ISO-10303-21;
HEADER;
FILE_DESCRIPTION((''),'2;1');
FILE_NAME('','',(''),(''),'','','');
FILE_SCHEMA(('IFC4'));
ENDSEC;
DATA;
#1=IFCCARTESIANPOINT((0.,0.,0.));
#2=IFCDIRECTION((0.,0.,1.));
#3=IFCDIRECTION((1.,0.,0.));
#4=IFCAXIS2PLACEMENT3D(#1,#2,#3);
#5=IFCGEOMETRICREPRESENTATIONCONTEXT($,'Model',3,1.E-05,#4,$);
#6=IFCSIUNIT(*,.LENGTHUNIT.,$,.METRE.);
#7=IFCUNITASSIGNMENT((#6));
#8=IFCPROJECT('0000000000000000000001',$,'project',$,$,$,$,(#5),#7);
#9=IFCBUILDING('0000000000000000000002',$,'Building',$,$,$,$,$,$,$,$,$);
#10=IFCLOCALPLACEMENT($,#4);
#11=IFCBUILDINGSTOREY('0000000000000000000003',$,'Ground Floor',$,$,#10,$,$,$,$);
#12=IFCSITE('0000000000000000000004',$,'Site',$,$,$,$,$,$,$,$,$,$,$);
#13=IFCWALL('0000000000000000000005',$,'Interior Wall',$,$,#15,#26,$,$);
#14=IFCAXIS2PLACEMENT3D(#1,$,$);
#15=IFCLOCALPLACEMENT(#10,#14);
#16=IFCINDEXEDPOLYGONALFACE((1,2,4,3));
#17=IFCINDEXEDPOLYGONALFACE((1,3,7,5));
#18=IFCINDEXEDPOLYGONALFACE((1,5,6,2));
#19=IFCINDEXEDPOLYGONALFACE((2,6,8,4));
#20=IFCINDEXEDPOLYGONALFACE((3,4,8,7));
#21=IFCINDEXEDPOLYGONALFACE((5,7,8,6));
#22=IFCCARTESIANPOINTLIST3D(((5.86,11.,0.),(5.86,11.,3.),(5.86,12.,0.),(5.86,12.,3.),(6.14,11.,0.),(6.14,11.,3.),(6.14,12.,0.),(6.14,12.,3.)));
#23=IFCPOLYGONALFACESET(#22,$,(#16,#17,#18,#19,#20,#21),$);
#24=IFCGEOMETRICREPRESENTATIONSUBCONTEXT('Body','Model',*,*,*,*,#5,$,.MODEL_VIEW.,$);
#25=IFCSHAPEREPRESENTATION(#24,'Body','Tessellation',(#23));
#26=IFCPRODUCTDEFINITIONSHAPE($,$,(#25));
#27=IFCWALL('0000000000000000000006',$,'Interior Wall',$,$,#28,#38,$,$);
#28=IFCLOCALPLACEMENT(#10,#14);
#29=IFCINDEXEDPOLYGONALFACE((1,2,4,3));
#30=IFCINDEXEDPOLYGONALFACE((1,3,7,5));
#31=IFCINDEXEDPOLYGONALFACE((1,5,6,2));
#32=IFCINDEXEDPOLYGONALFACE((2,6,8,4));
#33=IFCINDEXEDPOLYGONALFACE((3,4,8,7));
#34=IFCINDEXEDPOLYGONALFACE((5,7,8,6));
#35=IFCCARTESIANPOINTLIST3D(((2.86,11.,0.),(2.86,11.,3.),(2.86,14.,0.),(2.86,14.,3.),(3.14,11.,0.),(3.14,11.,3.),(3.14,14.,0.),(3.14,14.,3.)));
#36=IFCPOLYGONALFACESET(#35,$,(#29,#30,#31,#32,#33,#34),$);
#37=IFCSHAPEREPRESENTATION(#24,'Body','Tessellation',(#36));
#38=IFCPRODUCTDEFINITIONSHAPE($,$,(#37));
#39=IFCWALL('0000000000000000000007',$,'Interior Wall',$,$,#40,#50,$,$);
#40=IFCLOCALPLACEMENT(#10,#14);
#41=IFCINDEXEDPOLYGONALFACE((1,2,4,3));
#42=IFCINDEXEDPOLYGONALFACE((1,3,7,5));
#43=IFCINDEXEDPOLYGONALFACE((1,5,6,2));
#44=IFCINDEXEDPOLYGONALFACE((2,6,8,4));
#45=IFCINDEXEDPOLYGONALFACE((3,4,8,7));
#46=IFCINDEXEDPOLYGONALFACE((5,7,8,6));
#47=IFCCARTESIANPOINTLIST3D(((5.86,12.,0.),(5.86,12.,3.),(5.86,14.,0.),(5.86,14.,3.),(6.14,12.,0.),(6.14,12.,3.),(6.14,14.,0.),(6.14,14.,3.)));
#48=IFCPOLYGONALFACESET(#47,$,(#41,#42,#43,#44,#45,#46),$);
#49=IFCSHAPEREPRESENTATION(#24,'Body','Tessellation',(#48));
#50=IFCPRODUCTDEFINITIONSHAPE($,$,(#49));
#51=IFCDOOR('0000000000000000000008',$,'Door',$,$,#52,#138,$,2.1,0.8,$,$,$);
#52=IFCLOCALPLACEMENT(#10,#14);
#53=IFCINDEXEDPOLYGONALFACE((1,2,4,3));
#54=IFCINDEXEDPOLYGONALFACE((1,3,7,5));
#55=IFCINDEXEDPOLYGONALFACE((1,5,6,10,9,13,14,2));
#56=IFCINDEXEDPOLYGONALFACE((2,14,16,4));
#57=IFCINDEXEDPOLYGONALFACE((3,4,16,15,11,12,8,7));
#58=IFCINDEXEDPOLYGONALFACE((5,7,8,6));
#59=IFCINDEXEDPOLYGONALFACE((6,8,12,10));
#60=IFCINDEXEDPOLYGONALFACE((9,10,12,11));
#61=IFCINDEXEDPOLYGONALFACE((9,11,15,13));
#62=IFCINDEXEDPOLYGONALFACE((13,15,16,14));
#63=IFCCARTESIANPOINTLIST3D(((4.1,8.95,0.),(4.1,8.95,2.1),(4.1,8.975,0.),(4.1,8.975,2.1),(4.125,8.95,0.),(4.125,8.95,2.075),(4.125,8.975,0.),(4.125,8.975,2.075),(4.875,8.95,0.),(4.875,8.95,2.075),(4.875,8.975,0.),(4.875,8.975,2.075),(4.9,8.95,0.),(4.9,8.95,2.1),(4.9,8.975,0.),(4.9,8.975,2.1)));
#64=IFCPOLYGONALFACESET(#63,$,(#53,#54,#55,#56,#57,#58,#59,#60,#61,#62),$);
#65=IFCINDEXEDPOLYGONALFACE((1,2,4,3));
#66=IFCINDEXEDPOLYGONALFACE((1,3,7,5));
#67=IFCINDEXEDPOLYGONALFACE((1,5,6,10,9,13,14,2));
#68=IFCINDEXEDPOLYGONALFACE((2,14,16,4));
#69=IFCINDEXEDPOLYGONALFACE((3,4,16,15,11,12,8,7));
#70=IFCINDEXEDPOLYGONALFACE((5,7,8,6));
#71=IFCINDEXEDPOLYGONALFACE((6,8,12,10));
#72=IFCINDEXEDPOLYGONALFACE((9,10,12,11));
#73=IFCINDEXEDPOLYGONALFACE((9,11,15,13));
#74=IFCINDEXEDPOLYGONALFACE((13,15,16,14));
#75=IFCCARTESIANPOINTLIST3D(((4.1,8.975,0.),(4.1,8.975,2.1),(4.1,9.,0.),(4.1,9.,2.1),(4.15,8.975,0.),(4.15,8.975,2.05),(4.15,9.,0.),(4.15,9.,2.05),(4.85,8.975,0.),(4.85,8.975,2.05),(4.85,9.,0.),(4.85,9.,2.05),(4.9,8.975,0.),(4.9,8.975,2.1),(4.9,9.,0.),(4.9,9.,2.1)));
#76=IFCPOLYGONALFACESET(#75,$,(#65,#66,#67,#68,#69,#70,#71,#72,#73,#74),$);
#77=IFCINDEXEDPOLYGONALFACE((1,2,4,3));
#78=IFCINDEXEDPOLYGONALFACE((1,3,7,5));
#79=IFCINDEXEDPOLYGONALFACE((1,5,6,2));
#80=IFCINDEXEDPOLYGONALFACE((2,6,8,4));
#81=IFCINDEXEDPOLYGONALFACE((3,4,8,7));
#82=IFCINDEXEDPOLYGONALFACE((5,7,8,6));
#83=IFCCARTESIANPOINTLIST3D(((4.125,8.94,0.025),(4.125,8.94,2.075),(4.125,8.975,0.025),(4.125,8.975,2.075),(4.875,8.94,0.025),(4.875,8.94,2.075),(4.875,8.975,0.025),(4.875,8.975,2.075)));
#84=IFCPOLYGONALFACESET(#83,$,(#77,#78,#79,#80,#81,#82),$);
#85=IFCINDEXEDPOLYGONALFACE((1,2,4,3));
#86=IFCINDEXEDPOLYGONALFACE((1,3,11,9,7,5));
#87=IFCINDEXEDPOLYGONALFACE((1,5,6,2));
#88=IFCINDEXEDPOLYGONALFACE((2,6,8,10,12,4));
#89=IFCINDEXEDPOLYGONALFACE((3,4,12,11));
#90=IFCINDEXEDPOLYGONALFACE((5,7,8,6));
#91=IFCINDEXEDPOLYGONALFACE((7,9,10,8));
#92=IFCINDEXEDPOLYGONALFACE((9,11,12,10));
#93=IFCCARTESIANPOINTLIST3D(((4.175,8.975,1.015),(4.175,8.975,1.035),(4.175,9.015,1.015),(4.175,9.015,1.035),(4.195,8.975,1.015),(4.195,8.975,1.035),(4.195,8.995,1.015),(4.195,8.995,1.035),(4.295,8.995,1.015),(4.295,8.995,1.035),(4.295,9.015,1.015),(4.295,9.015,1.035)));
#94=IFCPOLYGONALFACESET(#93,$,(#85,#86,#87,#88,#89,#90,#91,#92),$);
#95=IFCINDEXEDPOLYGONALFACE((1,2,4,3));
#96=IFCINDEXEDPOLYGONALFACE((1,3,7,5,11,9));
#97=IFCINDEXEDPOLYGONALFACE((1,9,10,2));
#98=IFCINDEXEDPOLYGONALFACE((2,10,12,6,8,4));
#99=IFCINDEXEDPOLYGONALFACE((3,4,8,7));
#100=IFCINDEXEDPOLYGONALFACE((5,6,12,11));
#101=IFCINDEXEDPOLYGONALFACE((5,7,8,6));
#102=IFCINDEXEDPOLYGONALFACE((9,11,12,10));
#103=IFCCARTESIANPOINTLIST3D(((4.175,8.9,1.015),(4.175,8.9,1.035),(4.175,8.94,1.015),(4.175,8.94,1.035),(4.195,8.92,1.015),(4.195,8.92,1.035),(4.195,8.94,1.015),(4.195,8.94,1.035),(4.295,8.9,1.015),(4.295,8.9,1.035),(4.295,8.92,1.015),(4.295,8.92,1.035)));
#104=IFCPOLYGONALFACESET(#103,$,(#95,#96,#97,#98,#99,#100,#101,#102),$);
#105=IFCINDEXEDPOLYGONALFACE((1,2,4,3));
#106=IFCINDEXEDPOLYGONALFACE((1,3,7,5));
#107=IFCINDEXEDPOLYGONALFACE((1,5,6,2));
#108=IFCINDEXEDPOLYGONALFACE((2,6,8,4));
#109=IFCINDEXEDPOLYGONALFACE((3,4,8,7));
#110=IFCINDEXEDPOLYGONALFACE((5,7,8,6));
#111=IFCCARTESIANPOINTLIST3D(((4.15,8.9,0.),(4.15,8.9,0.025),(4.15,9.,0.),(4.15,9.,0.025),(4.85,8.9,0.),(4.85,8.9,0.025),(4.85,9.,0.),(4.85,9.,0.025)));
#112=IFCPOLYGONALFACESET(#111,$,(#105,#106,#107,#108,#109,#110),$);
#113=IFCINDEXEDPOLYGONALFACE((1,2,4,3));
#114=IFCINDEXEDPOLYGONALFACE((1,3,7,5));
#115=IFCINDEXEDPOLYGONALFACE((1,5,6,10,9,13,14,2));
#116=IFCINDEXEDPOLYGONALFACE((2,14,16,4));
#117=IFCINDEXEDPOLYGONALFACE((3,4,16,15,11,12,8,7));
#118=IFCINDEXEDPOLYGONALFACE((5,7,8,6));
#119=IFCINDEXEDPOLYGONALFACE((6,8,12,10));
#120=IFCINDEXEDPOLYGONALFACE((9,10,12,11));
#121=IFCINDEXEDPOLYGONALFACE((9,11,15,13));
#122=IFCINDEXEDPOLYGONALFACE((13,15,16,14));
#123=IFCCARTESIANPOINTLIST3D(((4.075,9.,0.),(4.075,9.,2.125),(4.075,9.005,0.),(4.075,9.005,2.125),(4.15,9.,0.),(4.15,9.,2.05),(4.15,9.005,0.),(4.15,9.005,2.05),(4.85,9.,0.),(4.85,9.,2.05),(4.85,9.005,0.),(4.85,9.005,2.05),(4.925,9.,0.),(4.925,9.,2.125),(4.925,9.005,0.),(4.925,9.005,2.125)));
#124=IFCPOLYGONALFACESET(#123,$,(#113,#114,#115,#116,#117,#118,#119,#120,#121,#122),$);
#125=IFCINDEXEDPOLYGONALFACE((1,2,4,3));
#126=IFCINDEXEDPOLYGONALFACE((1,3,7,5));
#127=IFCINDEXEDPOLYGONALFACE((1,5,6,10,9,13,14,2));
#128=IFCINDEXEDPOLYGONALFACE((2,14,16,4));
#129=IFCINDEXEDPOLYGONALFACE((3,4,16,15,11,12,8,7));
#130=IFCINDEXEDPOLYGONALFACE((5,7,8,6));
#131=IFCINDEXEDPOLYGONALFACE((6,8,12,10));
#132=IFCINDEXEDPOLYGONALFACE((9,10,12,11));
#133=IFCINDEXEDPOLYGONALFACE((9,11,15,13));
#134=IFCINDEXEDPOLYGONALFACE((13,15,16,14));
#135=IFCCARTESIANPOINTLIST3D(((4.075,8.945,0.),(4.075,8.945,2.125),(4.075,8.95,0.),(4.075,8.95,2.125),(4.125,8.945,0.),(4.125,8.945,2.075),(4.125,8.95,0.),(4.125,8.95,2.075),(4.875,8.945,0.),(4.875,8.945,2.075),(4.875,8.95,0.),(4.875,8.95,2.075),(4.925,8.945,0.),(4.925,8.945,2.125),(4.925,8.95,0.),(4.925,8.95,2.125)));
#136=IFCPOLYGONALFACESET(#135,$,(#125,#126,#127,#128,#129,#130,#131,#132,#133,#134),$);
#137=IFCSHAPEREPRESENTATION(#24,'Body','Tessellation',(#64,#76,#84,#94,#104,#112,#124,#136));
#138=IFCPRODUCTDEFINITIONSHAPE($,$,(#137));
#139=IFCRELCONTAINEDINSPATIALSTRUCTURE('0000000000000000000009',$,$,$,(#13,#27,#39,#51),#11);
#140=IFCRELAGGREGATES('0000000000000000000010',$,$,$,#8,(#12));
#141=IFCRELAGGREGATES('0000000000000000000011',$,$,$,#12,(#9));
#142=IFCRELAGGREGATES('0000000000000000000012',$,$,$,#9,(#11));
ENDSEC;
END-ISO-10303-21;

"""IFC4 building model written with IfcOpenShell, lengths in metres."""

from ifc_helpers import new_model, si_unit, frame, origin_with_axes, place, context, subcontext, project, spatial, line, indexed_curve, outline, extrude, element, save


model = new_model("IFC4")

# Units and contexts
model_context = context("Model", 3, precision=1e-05, world=origin_with_axes())
body_context = subcontext(model_context, "Body", "Model", "MODEL_VIEW")
ifc_project = project(units=[si_unit("LENGTHUNIT", "METRE")], contexts=[model_context])

# Site, building, storey
site = spatial("IfcSite", under=ifc_project, Name="Site")
building = spatial("IfcBuilding", under=site, Name="Building")
storey_placement = place(None, origin_with_axes())
storey = spatial("IfcBuildingStorey", under=building, at=storey_placement, Name="Ground Floor")

# Walls
wall_1_placement = place(storey_placement, frame((6.0, 12.0, 0.0), z_axis=(0.0, 0.0, 1.0), x_axis=(0.0, -1.0, 0.0)))
element("IfcWall", 1, at=wall_1_placement, inside=storey, Name="Interior Wall", context=body_context, shape_type="SweptSolid", body=[
    extrude(outline(indexed_curve([(0.0, 0.0), (0.0, 0.28), (1.0, 0.28), (1.0, 0.0), (0.0, 0.0)], self_intersect=False)), frame((0.0, -0.14, 0.0), z_axis=(0.0, 0.0, 1.0), x_axis=(1.0, 0.0, 0.0)), (0.0, 0.0, 1.0), 3.0),
])
wall_2_placement = place(storey_placement, frame((3.0, 11.0, 0.0), z_axis=(0.0, 0.0, 1.0), x_axis=(0.0, 1.0, 0.0)))
element("IfcWall", 2, at=wall_2_placement, inside=storey, Name="Interior Wall", context=body_context, shape_type="SweptSolid", body=[
    extrude(outline(indexed_curve([(0.0, 0.0), (0.0, 0.28), (3.0, 0.28), (3.0, 0.0), (0.0, 0.0)], self_intersect=False)), frame((0.0, -0.14, 0.0), z_axis=(0.0, 0.0, 1.0), x_axis=(1.0, 0.0, 0.0)), (0.0, 0.0, 1.0), 3.0),
])
wall_3_placement = place(storey_placement, frame((6.0, 12.0, 0.0), z_axis=(0.0, 0.0, 1.0), x_axis=(0.0, 1.0, 0.0)))
element("IfcWall", 3, at=wall_3_placement, inside=storey, Name="Interior Wall", context=body_context, shape_type="SweptSolid", body=[
    extrude(outline(indexed_curve([(0.0, 0.0), (0.0, 0.28), (2.0, 0.28), (2.0, 0.0), (0.0, 0.0)], self_intersect=False)), frame((0.0, -0.14, 0.0), z_axis=(0.0, 0.0, 1.0), x_axis=(1.0, 0.0, 0.0)), (0.0, 0.0, 1.0), 3.0),
])

# Door
door_1_placement = place(storey_placement, frame((4.9, 9.0, 0.0), z_axis=(0.0, 0.0, 1.0), x_axis=(-1.0, 0.0, 0.0)))
element("IfcDoor", 4, at=door_1_placement, inside=storey, Name="Door", OverallHeight=2.1, OverallWidth=0.8, context=body_context, shape_type="SweptSolid", body=[
    extrude(outline(indexed_curve([(0.0, 0.0), (0.0, 2.1), (0.8, 2.1), (0.8, 0.0), (0.775, 0.0), (0.775, 2.075), (0.025, 2.075), (0.025, 0.0)], segments=[line(1, 2, 3, 4, 5, 6, 7, 8, 1)])), frame((0.0, 0.025, 0.0), z_axis=(0.0, -1.0, 0.0), x_axis=(1.0, 0.0, 0.0)), (0.0, 0.0, -1.0), 0.025),
    extrude(outline(indexed_curve([(0.0, 0.0), (0.0, 2.1), (0.8, 2.1), (0.8, 0.0), (0.75, 0.0), (0.75, 2.05), (0.05, 2.05), (0.05, 0.0)], segments=[line(1, 2, 3, 4, 5, 6, 7, 8, 1)])), frame((0.0, 0.0, 0.0), z_axis=(0.0, -1.0, 0.0), x_axis=(1.0, 0.0, 0.0)), (0.0, 0.0, -1.0), 0.025),
    extrude(outline(indexed_curve([(0.0, 0.0), (0.75, 0.0), (0.75, 0.035), (0.0, 0.035)], segments=[line(1, 2, 3, 4, 1)])), frame((0.025, 0.025, 0.025), z_axis=(0.0, 0.0, 1.0), x_axis=(1.0, 0.0, 0.0)), (0.0, 0.0, 1.0), 2.05),
    extrude(outline(indexed_curve([(0.0, 0.0), (0.0, -0.04), (-0.12, -0.04), (-0.12, -0.02), (-0.02, -0.02), (-0.02, 0.0)], segments=[line(1, 2, 3, 4, 5, 6, 1)])), frame((0.725, 0.025, 1.015), z_axis=(0.0, 0.0, 1.0), x_axis=(1.0, 0.0, 0.0)), (0.0, 0.0, 1.0), 0.02),
    extrude(outline(indexed_curve([(0.0, 0.0), (0.0, 0.04), (-0.12, 0.04), (-0.12, 0.02), (-0.02, 0.02), (-0.02, 0.0)], segments=[line(1, 2, 3, 4, 5, 6, 1)])), frame((0.725, 0.06, 1.015), z_axis=(0.0, 0.0, 1.0), x_axis=(1.0, 0.0, 0.0)), (0.0, 0.0, 1.0), 0.02),
    extrude(outline(indexed_curve([(0.0, 0.0), (0.7, 0.0), (0.7, 0.1), (0.0, 0.1)], segments=[line(1, 2, 3, 4, 1)])), frame((0.05, 0.0, 0.0), z_axis=(0.0, 0.0, 1.0), x_axis=(1.0, 0.0, 0.0)), (0.0, 0.0, 1.0), 0.025),
    extrude(outline(indexed_curve([(0.0, 0.0), (0.0, 2.125), (0.85, 2.125), (0.85, 0.0), (0.775, 0.0), (0.775, 2.05), (0.075, 2.05), (0.075, 0.0)], segments=[line(1, 2, 3, 4, 5, 6, 7, 8, 1)])), frame((-0.025, -0.005, 0.0), z_axis=(0.0, -1.0, 0.0), x_axis=(1.0, 0.0, 0.0)), (0.0, 0.0, -1.0), 0.005),
    extrude(outline(indexed_curve([(0.0, 0.0), (0.0, 2.125), (0.85, 2.125), (0.85, 0.0), (0.8, 0.0), (0.8, 2.075), (0.05, 2.075), (0.05, 0.0)], segments=[line(1, 2, 3, 4, 5, 6, 7, 8, 1)])), frame((-0.025, 0.05, 0.0), z_axis=(0.0, -1.0, 0.0), x_axis=(1.0, 0.0, 0.0)), (0.0, 0.0, -1.0), 0.005),
])

save(model, "model.ifc")
